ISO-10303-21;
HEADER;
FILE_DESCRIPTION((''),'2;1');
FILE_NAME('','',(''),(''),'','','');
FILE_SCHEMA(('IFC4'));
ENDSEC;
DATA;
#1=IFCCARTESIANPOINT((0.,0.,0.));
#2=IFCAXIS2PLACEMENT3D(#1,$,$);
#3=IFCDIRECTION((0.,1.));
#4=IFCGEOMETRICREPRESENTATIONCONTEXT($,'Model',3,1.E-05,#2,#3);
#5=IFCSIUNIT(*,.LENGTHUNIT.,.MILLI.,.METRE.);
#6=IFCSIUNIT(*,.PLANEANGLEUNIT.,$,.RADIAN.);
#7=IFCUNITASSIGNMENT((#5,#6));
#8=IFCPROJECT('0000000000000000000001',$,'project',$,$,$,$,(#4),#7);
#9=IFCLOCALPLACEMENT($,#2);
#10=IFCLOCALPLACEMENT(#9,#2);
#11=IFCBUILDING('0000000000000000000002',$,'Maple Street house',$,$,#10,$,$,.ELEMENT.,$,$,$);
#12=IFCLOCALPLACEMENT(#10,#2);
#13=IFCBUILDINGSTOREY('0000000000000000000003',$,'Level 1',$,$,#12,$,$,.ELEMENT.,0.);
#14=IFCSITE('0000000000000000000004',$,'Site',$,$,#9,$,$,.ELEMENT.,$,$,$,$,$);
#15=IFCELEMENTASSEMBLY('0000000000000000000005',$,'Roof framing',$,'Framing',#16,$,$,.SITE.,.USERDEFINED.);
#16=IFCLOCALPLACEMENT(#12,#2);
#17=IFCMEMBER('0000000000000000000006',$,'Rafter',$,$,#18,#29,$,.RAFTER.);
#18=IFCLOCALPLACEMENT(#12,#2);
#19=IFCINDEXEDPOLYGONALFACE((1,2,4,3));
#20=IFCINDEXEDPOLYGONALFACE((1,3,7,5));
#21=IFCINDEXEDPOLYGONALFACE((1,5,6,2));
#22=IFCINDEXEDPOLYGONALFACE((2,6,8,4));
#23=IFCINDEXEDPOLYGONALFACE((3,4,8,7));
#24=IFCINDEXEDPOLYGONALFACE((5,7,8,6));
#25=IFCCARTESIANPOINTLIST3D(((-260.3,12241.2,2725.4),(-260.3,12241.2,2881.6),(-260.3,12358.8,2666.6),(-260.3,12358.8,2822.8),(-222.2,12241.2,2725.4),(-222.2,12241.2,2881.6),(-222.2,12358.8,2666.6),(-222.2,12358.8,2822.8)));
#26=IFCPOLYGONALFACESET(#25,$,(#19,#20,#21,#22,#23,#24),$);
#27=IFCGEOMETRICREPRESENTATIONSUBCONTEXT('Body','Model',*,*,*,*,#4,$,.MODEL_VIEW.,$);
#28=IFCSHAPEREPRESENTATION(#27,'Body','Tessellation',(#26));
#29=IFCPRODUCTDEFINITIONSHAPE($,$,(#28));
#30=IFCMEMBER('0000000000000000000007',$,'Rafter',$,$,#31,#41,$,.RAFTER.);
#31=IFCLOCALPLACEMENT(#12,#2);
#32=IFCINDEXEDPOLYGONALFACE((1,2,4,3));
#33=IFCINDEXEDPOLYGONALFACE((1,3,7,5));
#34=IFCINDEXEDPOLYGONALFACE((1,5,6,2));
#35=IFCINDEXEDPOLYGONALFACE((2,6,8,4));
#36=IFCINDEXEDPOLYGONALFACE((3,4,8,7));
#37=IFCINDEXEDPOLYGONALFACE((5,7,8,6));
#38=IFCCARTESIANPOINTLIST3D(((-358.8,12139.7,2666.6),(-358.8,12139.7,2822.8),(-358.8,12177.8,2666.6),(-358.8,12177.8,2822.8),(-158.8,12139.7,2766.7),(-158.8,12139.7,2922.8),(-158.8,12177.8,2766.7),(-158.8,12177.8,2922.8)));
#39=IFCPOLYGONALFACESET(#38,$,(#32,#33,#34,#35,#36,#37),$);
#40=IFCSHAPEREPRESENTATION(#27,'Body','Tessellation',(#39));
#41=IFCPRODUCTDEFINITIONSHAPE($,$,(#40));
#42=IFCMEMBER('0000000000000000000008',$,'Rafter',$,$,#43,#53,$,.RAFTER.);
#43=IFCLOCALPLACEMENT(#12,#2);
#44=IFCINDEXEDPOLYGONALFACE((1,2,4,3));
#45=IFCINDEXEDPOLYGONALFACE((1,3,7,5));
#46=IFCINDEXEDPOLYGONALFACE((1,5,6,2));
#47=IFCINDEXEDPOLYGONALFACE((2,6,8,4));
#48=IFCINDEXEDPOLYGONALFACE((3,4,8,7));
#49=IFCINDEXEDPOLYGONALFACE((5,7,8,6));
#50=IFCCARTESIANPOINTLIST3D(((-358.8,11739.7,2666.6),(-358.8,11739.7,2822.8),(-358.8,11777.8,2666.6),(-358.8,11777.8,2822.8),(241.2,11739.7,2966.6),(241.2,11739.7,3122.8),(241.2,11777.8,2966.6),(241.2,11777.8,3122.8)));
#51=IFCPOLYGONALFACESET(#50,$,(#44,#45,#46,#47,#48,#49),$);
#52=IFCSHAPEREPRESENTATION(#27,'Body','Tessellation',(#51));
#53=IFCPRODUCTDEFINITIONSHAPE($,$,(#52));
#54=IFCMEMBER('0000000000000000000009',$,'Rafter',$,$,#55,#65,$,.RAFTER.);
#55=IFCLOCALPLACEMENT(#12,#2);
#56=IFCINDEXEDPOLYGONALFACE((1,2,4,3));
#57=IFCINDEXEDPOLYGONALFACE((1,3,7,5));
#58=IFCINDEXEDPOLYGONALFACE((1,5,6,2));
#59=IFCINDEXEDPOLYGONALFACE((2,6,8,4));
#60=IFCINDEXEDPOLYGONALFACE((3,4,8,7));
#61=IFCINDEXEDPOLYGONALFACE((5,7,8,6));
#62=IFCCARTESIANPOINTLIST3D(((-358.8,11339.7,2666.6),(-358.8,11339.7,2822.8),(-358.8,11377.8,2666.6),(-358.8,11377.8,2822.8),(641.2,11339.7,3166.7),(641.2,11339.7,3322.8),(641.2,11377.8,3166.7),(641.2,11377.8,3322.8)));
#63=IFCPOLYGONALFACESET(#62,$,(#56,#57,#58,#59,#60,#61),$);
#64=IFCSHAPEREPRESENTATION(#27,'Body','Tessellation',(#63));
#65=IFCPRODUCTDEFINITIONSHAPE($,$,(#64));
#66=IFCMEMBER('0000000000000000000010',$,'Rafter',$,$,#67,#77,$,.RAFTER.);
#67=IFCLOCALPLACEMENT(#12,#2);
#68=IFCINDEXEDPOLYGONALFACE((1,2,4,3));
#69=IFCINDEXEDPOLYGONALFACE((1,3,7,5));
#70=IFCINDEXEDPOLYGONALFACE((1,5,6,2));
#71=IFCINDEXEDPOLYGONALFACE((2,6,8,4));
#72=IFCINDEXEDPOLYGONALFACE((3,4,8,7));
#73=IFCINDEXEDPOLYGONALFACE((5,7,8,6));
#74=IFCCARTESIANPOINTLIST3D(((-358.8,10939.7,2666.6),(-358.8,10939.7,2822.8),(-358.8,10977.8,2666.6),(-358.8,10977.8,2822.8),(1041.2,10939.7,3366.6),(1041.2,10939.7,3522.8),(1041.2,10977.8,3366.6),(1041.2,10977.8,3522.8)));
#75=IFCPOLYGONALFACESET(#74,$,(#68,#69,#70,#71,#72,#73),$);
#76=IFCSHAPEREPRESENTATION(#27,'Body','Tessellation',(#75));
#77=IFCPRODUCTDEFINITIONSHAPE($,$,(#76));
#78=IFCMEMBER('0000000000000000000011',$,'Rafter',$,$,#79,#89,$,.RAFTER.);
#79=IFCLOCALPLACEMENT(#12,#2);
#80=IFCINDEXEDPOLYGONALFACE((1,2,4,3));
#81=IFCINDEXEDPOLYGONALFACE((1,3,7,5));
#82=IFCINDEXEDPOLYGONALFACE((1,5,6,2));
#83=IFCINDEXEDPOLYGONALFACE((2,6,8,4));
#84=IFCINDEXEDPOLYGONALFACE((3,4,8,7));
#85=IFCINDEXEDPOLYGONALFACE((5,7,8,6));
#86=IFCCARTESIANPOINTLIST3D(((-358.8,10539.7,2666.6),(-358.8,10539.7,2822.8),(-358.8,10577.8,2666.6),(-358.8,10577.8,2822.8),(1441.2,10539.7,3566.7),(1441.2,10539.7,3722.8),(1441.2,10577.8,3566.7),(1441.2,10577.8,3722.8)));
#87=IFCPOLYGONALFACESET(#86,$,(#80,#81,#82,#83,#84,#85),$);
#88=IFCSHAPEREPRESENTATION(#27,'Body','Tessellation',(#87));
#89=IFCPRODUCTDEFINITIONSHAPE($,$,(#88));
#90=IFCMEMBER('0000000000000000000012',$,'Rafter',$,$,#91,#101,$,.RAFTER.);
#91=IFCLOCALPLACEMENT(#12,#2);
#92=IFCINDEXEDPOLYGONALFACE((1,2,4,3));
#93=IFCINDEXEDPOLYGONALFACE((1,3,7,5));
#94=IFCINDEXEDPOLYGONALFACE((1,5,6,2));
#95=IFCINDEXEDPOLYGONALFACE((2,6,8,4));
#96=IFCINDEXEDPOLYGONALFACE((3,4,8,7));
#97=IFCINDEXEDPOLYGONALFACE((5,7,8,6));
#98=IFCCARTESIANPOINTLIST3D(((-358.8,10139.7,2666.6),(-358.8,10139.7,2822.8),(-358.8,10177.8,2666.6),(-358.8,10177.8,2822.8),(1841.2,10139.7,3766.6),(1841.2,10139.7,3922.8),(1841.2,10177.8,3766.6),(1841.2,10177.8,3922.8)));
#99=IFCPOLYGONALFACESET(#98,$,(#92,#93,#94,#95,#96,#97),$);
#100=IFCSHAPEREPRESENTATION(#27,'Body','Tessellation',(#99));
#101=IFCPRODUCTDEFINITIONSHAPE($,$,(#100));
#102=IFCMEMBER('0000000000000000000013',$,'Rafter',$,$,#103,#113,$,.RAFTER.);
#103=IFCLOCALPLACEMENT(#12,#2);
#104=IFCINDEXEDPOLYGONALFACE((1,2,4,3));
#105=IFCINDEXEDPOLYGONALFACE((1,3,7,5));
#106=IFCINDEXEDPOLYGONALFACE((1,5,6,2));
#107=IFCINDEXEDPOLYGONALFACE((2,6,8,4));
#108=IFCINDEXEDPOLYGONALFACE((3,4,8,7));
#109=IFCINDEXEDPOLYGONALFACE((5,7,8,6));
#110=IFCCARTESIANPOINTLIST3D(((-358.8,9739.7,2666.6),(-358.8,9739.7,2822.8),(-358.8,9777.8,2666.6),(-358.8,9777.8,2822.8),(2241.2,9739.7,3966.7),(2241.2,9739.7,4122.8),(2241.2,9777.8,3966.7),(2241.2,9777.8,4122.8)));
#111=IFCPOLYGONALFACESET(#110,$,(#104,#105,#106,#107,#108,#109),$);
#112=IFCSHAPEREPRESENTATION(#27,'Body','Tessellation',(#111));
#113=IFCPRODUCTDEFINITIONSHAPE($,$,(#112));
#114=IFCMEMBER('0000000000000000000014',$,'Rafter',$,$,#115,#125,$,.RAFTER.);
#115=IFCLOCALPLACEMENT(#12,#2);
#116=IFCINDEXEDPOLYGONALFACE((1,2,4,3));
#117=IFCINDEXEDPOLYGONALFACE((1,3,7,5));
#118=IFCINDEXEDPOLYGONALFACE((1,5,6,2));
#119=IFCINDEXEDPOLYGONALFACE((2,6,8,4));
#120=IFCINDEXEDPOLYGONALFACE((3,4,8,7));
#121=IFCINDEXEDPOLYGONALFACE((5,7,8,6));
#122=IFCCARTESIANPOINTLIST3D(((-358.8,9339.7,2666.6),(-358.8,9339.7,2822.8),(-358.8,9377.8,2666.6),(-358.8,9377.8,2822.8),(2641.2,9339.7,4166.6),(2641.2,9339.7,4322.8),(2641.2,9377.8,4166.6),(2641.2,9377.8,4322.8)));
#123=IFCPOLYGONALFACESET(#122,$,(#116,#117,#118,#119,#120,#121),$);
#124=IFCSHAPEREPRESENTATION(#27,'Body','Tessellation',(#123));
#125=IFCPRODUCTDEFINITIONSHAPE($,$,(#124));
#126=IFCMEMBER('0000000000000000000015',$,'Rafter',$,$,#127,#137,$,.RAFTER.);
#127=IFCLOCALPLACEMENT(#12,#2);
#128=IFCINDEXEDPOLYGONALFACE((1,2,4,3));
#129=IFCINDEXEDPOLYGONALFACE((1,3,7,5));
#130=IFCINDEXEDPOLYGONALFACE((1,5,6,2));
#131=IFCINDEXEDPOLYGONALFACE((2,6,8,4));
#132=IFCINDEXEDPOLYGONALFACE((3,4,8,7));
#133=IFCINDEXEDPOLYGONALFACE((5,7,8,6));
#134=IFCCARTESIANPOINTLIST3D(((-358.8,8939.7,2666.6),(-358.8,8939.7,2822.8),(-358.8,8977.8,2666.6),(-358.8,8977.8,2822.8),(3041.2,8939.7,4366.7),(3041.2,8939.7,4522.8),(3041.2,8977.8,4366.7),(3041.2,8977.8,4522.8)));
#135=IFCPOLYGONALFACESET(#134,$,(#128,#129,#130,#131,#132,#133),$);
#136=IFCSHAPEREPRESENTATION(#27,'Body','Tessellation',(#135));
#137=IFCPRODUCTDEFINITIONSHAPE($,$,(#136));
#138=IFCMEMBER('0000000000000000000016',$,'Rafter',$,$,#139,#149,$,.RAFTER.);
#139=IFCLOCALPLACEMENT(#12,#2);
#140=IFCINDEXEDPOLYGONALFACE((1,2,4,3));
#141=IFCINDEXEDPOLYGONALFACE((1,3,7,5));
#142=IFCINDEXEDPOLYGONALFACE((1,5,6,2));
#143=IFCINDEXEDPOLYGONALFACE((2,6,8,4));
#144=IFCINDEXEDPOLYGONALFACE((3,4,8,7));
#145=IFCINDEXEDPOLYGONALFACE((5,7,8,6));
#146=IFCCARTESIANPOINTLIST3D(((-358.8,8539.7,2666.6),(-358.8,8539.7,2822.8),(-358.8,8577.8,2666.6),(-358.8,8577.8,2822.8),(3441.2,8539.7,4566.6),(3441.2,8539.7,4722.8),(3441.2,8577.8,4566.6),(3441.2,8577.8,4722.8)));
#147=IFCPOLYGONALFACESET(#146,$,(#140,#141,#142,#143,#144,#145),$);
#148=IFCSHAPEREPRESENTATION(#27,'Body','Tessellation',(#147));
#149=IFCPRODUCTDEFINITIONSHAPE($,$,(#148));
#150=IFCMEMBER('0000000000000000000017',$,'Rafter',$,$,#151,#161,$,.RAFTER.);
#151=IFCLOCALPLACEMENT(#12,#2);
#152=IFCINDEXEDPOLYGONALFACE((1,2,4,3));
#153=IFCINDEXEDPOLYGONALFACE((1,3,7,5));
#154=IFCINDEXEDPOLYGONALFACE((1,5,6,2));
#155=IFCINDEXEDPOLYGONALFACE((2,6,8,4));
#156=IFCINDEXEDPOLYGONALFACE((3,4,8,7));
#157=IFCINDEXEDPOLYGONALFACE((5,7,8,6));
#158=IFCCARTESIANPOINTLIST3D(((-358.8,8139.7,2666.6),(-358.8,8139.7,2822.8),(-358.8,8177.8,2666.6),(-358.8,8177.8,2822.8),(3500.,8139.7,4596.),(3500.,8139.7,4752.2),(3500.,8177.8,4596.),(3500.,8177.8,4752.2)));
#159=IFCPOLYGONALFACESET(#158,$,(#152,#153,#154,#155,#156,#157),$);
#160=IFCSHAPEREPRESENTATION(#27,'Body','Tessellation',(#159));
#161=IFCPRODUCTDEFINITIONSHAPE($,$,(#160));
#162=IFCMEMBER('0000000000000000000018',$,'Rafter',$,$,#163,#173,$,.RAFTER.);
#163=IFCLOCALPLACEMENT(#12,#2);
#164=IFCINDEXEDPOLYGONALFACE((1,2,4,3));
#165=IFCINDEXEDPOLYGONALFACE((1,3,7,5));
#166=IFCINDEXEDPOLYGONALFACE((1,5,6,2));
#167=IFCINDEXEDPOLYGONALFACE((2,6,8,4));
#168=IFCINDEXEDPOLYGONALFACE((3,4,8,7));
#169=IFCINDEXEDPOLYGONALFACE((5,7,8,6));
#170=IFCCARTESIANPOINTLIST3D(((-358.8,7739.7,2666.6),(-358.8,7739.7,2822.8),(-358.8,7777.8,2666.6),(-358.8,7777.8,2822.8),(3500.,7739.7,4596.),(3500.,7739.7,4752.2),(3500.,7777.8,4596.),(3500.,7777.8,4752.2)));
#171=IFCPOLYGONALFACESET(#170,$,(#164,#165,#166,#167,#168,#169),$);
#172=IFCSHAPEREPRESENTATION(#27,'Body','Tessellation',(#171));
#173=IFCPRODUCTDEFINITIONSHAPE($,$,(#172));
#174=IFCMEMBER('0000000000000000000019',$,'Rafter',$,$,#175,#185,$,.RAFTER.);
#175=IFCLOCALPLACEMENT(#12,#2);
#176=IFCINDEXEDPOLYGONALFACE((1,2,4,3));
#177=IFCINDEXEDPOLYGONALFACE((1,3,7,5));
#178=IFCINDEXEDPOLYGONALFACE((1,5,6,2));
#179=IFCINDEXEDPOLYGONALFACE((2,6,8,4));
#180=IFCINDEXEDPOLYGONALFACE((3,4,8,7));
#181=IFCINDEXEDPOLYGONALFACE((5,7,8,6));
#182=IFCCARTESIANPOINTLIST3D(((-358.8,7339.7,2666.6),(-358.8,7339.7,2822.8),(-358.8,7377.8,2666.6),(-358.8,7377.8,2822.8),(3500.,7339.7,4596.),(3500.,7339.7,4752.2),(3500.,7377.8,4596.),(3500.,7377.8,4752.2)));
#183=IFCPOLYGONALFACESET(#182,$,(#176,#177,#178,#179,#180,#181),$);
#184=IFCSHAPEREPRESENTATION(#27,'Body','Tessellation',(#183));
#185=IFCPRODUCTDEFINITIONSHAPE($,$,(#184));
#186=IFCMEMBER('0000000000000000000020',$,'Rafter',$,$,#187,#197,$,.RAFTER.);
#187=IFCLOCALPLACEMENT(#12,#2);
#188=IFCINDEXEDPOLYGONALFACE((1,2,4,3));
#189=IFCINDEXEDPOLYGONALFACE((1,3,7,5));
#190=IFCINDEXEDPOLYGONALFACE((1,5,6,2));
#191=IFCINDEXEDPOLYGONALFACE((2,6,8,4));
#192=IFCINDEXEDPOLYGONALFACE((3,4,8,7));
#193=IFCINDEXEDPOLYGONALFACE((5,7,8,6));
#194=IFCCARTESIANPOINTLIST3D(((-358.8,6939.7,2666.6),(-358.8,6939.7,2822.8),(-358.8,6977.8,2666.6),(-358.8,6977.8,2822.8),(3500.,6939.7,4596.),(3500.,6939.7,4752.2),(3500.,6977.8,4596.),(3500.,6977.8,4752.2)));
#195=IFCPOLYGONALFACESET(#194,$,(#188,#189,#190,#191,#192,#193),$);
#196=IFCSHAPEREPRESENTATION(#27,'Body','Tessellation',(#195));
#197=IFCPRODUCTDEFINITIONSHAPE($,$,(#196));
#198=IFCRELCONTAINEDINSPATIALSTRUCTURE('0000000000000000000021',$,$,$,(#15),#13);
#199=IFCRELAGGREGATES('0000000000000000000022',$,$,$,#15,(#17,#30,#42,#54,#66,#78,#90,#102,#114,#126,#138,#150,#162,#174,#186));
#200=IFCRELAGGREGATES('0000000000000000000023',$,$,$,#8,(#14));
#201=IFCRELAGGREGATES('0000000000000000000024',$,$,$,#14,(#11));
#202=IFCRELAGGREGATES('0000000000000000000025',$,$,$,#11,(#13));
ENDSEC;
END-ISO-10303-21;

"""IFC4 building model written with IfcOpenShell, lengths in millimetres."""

from ifc_helpers import new_model, si_unit, direction, frame, origin, origin_with_axes, place, context, subcontext, project, spatial, polyline, outline, extrude, element, aggregate, save


model = new_model("IFC4")

# Units and contexts
model_context = context("Model", 3, precision=1e-05, world=origin(), true_north=direction((0.0, 1.0)))
body_context = subcontext(model_context, "Body", "Model", "MODEL_VIEW")
ifc_project = project(units=[si_unit("LENGTHUNIT", "METRE", prefix="MILLI"), si_unit("PLANEANGLEUNIT", "RADIAN")], contexts=[model_context])

# Site, building, storey
site_placement = place(None, origin())
site = spatial("IfcSite", under=ifc_project, at=site_placement, Name="Site", CompositionType="ELEMENT")
building_placement = place(site_placement, origin())
building = spatial("IfcBuilding", under=site, at=building_placement, Name="Maple Street house", CompositionType="ELEMENT")
storey_placement = place(building_placement, origin())
storey = spatial("IfcBuildingStorey", under=building, at=storey_placement, Name="Level 1", CompositionType="ELEMENT", Elevation=0.0)

# Element assembly, members
assembly_placement = place(storey_placement, origin_with_axes())
assembly = element("IfcElementAssembly", 1, at=assembly_placement, inside=storey, Name="Roof framing", ObjectType="Framing", AssemblyPlace="SITE", PredefinedType="USERDEFINED")
member_1_placement = place(storey_placement, origin_with_axes())
member_1 = element("IfcMember", 2, at=member_1_placement, Name="Rafter", PredefinedType="RAFTER", context=body_context, shape_type="SweptSolid", body=[
    extrude(outline(polyline([(0.0, 0.0), (38.1, 0.0), (38.1, 156.2), (0.0, 156.2), (0.0, 0.0)])), frame((-260.3, 12358.8, 2666.7), z_axis=(0.0, -1.0, 0.0), x_axis=(1.0, 0.0, 0.0)), (0.0, 0.447214, 0.894427), 131.4),
])
member_2_placement = place(storey_placement, origin_with_axes())
member_2 = element("IfcMember", 3, at=member_2_placement, Name="Rafter", PredefinedType="RAFTER", context=body_context, shape_type="SweptSolid", body=[
    extrude(outline(polyline([(0.0, 0.0), (38.1, 0.0), (38.1, 156.2), (0.0, 156.2), (0.0, 0.0)])), frame((-358.8, 12139.7, 2666.7), z_axis=(1.0, 0.0, 0.0), x_axis=(0.0, 1.0, 0.0)), (0.0, 0.447214, 0.894427), 223.6),
])
member_3_placement = place(storey_placement, origin_with_axes())
member_3 = element("IfcMember", 4, at=member_3_placement, Name="Rafter", PredefinedType="RAFTER", context=body_context, shape_type="SweptSolid", body=[
    extrude(outline(polyline([(0.0, 0.0), (38.1, 0.0), (38.1, 156.2), (0.0, 156.2), (0.0, 0.0)])), frame((-358.8, 11739.7, 2666.7), z_axis=(1.0, 0.0, 0.0), x_axis=(0.0, 1.0, 0.0)), (0.0, 0.447214, 0.894427), 670.8),
])
member_4_placement = place(storey_placement, origin_with_axes())
member_4 = element("IfcMember", 5, at=member_4_placement, Name="Rafter", PredefinedType="RAFTER", context=body_context, shape_type="SweptSolid", body=[
    extrude(outline(polyline([(0.0, 0.0), (38.1, 0.0), (38.1, 156.2), (0.0, 156.2), (0.0, 0.0)])), frame((-358.8, 11339.7, 2666.7), z_axis=(1.0, 0.0, 0.0), x_axis=(0.0, 1.0, 0.0)), (0.0, 0.447214, 0.894427), 1118.0),
])
member_5_placement = place(storey_placement, origin_with_axes())
member_5 = element("IfcMember", 6, at=member_5_placement, Name="Rafter", PredefinedType="RAFTER", context=body_context, shape_type="SweptSolid", body=[
    extrude(outline(polyline([(0.0, 0.0), (38.1, 0.0), (38.1, 156.2), (0.0, 156.2), (0.0, 0.0)])), frame((-358.8, 10939.7, 2666.7), z_axis=(1.0, 0.0, 0.0), x_axis=(0.0, 1.0, 0.0)), (0.0, 0.447214, 0.894427), 1565.2),
])
member_6_placement = place(storey_placement, origin_with_axes())
member_6 = element("IfcMember", 7, at=member_6_placement, Name="Rafter", PredefinedType="RAFTER", context=body_context, shape_type="SweptSolid", body=[
    extrude(outline(polyline([(0.0, 0.0), (38.1, 0.0), (38.1, 156.2), (0.0, 156.2), (0.0, 0.0)])), frame((-358.8, 10539.7, 2666.7), z_axis=(1.0, 0.0, 0.0), x_axis=(0.0, 1.0, 0.0)), (0.0, 0.447214, 0.894427), 2012.5),
])
member_7_placement = place(storey_placement, origin_with_axes())
member_7 = element("IfcMember", 8, at=member_7_placement, Name="Rafter", PredefinedType="RAFTER", context=body_context, shape_type="SweptSolid", body=[
    extrude(outline(polyline([(0.0, 0.0), (38.1, 0.0), (38.1, 156.2), (0.0, 156.2), (0.0, 0.0)])), frame((-358.8, 10139.7, 2666.7), z_axis=(1.0, 0.0, 0.0), x_axis=(0.0, 1.0, 0.0)), (0.0, 0.447214, 0.894427), 2459.7),
])
member_8_placement = place(storey_placement, origin_with_axes())
member_8 = element("IfcMember", 9, at=member_8_placement, Name="Rafter", PredefinedType="RAFTER", context=body_context, shape_type="SweptSolid", body=[
    extrude(outline(polyline([(0.0, 0.0), (38.1, 0.0), (38.1, 156.2), (0.0, 156.2), (0.0, 0.0)])), frame((-358.8, 9739.7, 2666.7), z_axis=(1.0, 0.0, 0.0), x_axis=(0.0, 1.0, 0.0)), (0.0, 0.447214, 0.894427), 2906.9),
])
member_9_placement = place(storey_placement, origin_with_axes())
member_9 = element("IfcMember", 10, at=member_9_placement, Name="Rafter", PredefinedType="RAFTER", context=body_context, shape_type="SweptSolid", body=[
    extrude(outline(polyline([(0.0, 0.0), (38.1, 0.0), (38.1, 156.2), (0.0, 156.2), (0.0, 0.0)])), frame((-358.8, 9339.7, 2666.7), z_axis=(1.0, 0.0, 0.0), x_axis=(0.0, 1.0, 0.0)), (0.0, 0.447214, 0.894427), 3354.1),
])
member_10_placement = place(storey_placement, origin_with_axes())
member_10 = element("IfcMember", 11, at=member_10_placement, Name="Rafter", PredefinedType="RAFTER", context=body_context, shape_type="SweptSolid", body=[
    extrude(outline(polyline([(0.0, 0.0), (38.1, 0.0), (38.1, 156.2), (0.0, 156.2), (0.0, 0.0)])), frame((-358.8, 8939.7, 2666.7), z_axis=(1.0, 0.0, 0.0), x_axis=(0.0, 1.0, 0.0)), (0.0, 0.447214, 0.894427), 3801.3),
])
member_11_placement = place(storey_placement, origin_with_axes())
member_11 = element("IfcMember", 12, at=member_11_placement, Name="Rafter", PredefinedType="RAFTER", context=body_context, shape_type="SweptSolid", body=[
    extrude(outline(polyline([(0.0, 0.0), (38.1, 0.0), (38.1, 156.2), (0.0, 156.2), (0.0, 0.0)])), frame((-358.8, 8539.7, 2666.7), z_axis=(1.0, 0.0, 0.0), x_axis=(0.0, 1.0, 0.0)), (0.0, 0.447214, 0.894427), 4248.5),
])
member_12_placement = place(storey_placement, origin_with_axes())
member_12 = element("IfcMember", 13, at=member_12_placement, Name="Rafter", PredefinedType="RAFTER", context=body_context, shape_type="SweptSolid", body=[
    extrude(outline(polyline([(0.0, 0.0), (38.1, 0.0), (38.1, 156.2), (0.0, 156.2), (0.0, 0.0)])), frame((-358.8, 8139.7, 2666.7), z_axis=(1.0, 0.0, 0.0), x_axis=(0.0, 1.0, 0.0)), (0.0, 0.447214, 0.894427), 4314.2),
])
member_13_placement = place(storey_placement, origin_with_axes())
member_13 = element("IfcMember", 14, at=member_13_placement, Name="Rafter", PredefinedType="RAFTER", context=body_context, shape_type="SweptSolid", body=[
    extrude(outline(polyline([(0.0, 0.0), (38.1, 0.0), (38.1, 156.2), (0.0, 156.2), (0.0, 0.0)])), frame((-358.8, 7739.7, 2666.7), z_axis=(1.0, 0.0, 0.0), x_axis=(0.0, 1.0, 0.0)), (0.0, 0.447214, 0.894427), 4314.2),
])
member_14_placement = place(storey_placement, origin_with_axes())
member_14 = element("IfcMember", 15, at=member_14_placement, Name="Rafter", PredefinedType="RAFTER", context=body_context, shape_type="SweptSolid", body=[
    extrude(outline(polyline([(0.0, 0.0), (38.1, 0.0), (38.1, 156.2), (0.0, 156.2), (0.0, 0.0)])), frame((-358.8, 7339.7, 2666.7), z_axis=(1.0, 0.0, 0.0), x_axis=(0.0, 1.0, 0.0)), (0.0, 0.447214, 0.894427), 4314.2),
])
member_15_placement = place(storey_placement, origin_with_axes())
member_15 = element("IfcMember", 16, at=member_15_placement, Name="Rafter", PredefinedType="RAFTER", context=body_context, shape_type="SweptSolid", body=[
    extrude(outline(polyline([(0.0, 0.0), (38.1, 0.0), (38.1, 156.2), (0.0, 156.2), (0.0, 0.0)])), frame((-358.8, 6939.7, 2666.7), z_axis=(1.0, 0.0, 0.0), x_axis=(0.0, 1.0, 0.0)), (0.0, 0.447214, 0.894427), 4314.2),
])
aggregate(assembly, [member_1, member_2, member_3, member_4, member_5, member_6, member_7, member_8, member_9, member_10, member_11, member_12, member_13, member_14, member_15])

save(model, "model.ifc")
